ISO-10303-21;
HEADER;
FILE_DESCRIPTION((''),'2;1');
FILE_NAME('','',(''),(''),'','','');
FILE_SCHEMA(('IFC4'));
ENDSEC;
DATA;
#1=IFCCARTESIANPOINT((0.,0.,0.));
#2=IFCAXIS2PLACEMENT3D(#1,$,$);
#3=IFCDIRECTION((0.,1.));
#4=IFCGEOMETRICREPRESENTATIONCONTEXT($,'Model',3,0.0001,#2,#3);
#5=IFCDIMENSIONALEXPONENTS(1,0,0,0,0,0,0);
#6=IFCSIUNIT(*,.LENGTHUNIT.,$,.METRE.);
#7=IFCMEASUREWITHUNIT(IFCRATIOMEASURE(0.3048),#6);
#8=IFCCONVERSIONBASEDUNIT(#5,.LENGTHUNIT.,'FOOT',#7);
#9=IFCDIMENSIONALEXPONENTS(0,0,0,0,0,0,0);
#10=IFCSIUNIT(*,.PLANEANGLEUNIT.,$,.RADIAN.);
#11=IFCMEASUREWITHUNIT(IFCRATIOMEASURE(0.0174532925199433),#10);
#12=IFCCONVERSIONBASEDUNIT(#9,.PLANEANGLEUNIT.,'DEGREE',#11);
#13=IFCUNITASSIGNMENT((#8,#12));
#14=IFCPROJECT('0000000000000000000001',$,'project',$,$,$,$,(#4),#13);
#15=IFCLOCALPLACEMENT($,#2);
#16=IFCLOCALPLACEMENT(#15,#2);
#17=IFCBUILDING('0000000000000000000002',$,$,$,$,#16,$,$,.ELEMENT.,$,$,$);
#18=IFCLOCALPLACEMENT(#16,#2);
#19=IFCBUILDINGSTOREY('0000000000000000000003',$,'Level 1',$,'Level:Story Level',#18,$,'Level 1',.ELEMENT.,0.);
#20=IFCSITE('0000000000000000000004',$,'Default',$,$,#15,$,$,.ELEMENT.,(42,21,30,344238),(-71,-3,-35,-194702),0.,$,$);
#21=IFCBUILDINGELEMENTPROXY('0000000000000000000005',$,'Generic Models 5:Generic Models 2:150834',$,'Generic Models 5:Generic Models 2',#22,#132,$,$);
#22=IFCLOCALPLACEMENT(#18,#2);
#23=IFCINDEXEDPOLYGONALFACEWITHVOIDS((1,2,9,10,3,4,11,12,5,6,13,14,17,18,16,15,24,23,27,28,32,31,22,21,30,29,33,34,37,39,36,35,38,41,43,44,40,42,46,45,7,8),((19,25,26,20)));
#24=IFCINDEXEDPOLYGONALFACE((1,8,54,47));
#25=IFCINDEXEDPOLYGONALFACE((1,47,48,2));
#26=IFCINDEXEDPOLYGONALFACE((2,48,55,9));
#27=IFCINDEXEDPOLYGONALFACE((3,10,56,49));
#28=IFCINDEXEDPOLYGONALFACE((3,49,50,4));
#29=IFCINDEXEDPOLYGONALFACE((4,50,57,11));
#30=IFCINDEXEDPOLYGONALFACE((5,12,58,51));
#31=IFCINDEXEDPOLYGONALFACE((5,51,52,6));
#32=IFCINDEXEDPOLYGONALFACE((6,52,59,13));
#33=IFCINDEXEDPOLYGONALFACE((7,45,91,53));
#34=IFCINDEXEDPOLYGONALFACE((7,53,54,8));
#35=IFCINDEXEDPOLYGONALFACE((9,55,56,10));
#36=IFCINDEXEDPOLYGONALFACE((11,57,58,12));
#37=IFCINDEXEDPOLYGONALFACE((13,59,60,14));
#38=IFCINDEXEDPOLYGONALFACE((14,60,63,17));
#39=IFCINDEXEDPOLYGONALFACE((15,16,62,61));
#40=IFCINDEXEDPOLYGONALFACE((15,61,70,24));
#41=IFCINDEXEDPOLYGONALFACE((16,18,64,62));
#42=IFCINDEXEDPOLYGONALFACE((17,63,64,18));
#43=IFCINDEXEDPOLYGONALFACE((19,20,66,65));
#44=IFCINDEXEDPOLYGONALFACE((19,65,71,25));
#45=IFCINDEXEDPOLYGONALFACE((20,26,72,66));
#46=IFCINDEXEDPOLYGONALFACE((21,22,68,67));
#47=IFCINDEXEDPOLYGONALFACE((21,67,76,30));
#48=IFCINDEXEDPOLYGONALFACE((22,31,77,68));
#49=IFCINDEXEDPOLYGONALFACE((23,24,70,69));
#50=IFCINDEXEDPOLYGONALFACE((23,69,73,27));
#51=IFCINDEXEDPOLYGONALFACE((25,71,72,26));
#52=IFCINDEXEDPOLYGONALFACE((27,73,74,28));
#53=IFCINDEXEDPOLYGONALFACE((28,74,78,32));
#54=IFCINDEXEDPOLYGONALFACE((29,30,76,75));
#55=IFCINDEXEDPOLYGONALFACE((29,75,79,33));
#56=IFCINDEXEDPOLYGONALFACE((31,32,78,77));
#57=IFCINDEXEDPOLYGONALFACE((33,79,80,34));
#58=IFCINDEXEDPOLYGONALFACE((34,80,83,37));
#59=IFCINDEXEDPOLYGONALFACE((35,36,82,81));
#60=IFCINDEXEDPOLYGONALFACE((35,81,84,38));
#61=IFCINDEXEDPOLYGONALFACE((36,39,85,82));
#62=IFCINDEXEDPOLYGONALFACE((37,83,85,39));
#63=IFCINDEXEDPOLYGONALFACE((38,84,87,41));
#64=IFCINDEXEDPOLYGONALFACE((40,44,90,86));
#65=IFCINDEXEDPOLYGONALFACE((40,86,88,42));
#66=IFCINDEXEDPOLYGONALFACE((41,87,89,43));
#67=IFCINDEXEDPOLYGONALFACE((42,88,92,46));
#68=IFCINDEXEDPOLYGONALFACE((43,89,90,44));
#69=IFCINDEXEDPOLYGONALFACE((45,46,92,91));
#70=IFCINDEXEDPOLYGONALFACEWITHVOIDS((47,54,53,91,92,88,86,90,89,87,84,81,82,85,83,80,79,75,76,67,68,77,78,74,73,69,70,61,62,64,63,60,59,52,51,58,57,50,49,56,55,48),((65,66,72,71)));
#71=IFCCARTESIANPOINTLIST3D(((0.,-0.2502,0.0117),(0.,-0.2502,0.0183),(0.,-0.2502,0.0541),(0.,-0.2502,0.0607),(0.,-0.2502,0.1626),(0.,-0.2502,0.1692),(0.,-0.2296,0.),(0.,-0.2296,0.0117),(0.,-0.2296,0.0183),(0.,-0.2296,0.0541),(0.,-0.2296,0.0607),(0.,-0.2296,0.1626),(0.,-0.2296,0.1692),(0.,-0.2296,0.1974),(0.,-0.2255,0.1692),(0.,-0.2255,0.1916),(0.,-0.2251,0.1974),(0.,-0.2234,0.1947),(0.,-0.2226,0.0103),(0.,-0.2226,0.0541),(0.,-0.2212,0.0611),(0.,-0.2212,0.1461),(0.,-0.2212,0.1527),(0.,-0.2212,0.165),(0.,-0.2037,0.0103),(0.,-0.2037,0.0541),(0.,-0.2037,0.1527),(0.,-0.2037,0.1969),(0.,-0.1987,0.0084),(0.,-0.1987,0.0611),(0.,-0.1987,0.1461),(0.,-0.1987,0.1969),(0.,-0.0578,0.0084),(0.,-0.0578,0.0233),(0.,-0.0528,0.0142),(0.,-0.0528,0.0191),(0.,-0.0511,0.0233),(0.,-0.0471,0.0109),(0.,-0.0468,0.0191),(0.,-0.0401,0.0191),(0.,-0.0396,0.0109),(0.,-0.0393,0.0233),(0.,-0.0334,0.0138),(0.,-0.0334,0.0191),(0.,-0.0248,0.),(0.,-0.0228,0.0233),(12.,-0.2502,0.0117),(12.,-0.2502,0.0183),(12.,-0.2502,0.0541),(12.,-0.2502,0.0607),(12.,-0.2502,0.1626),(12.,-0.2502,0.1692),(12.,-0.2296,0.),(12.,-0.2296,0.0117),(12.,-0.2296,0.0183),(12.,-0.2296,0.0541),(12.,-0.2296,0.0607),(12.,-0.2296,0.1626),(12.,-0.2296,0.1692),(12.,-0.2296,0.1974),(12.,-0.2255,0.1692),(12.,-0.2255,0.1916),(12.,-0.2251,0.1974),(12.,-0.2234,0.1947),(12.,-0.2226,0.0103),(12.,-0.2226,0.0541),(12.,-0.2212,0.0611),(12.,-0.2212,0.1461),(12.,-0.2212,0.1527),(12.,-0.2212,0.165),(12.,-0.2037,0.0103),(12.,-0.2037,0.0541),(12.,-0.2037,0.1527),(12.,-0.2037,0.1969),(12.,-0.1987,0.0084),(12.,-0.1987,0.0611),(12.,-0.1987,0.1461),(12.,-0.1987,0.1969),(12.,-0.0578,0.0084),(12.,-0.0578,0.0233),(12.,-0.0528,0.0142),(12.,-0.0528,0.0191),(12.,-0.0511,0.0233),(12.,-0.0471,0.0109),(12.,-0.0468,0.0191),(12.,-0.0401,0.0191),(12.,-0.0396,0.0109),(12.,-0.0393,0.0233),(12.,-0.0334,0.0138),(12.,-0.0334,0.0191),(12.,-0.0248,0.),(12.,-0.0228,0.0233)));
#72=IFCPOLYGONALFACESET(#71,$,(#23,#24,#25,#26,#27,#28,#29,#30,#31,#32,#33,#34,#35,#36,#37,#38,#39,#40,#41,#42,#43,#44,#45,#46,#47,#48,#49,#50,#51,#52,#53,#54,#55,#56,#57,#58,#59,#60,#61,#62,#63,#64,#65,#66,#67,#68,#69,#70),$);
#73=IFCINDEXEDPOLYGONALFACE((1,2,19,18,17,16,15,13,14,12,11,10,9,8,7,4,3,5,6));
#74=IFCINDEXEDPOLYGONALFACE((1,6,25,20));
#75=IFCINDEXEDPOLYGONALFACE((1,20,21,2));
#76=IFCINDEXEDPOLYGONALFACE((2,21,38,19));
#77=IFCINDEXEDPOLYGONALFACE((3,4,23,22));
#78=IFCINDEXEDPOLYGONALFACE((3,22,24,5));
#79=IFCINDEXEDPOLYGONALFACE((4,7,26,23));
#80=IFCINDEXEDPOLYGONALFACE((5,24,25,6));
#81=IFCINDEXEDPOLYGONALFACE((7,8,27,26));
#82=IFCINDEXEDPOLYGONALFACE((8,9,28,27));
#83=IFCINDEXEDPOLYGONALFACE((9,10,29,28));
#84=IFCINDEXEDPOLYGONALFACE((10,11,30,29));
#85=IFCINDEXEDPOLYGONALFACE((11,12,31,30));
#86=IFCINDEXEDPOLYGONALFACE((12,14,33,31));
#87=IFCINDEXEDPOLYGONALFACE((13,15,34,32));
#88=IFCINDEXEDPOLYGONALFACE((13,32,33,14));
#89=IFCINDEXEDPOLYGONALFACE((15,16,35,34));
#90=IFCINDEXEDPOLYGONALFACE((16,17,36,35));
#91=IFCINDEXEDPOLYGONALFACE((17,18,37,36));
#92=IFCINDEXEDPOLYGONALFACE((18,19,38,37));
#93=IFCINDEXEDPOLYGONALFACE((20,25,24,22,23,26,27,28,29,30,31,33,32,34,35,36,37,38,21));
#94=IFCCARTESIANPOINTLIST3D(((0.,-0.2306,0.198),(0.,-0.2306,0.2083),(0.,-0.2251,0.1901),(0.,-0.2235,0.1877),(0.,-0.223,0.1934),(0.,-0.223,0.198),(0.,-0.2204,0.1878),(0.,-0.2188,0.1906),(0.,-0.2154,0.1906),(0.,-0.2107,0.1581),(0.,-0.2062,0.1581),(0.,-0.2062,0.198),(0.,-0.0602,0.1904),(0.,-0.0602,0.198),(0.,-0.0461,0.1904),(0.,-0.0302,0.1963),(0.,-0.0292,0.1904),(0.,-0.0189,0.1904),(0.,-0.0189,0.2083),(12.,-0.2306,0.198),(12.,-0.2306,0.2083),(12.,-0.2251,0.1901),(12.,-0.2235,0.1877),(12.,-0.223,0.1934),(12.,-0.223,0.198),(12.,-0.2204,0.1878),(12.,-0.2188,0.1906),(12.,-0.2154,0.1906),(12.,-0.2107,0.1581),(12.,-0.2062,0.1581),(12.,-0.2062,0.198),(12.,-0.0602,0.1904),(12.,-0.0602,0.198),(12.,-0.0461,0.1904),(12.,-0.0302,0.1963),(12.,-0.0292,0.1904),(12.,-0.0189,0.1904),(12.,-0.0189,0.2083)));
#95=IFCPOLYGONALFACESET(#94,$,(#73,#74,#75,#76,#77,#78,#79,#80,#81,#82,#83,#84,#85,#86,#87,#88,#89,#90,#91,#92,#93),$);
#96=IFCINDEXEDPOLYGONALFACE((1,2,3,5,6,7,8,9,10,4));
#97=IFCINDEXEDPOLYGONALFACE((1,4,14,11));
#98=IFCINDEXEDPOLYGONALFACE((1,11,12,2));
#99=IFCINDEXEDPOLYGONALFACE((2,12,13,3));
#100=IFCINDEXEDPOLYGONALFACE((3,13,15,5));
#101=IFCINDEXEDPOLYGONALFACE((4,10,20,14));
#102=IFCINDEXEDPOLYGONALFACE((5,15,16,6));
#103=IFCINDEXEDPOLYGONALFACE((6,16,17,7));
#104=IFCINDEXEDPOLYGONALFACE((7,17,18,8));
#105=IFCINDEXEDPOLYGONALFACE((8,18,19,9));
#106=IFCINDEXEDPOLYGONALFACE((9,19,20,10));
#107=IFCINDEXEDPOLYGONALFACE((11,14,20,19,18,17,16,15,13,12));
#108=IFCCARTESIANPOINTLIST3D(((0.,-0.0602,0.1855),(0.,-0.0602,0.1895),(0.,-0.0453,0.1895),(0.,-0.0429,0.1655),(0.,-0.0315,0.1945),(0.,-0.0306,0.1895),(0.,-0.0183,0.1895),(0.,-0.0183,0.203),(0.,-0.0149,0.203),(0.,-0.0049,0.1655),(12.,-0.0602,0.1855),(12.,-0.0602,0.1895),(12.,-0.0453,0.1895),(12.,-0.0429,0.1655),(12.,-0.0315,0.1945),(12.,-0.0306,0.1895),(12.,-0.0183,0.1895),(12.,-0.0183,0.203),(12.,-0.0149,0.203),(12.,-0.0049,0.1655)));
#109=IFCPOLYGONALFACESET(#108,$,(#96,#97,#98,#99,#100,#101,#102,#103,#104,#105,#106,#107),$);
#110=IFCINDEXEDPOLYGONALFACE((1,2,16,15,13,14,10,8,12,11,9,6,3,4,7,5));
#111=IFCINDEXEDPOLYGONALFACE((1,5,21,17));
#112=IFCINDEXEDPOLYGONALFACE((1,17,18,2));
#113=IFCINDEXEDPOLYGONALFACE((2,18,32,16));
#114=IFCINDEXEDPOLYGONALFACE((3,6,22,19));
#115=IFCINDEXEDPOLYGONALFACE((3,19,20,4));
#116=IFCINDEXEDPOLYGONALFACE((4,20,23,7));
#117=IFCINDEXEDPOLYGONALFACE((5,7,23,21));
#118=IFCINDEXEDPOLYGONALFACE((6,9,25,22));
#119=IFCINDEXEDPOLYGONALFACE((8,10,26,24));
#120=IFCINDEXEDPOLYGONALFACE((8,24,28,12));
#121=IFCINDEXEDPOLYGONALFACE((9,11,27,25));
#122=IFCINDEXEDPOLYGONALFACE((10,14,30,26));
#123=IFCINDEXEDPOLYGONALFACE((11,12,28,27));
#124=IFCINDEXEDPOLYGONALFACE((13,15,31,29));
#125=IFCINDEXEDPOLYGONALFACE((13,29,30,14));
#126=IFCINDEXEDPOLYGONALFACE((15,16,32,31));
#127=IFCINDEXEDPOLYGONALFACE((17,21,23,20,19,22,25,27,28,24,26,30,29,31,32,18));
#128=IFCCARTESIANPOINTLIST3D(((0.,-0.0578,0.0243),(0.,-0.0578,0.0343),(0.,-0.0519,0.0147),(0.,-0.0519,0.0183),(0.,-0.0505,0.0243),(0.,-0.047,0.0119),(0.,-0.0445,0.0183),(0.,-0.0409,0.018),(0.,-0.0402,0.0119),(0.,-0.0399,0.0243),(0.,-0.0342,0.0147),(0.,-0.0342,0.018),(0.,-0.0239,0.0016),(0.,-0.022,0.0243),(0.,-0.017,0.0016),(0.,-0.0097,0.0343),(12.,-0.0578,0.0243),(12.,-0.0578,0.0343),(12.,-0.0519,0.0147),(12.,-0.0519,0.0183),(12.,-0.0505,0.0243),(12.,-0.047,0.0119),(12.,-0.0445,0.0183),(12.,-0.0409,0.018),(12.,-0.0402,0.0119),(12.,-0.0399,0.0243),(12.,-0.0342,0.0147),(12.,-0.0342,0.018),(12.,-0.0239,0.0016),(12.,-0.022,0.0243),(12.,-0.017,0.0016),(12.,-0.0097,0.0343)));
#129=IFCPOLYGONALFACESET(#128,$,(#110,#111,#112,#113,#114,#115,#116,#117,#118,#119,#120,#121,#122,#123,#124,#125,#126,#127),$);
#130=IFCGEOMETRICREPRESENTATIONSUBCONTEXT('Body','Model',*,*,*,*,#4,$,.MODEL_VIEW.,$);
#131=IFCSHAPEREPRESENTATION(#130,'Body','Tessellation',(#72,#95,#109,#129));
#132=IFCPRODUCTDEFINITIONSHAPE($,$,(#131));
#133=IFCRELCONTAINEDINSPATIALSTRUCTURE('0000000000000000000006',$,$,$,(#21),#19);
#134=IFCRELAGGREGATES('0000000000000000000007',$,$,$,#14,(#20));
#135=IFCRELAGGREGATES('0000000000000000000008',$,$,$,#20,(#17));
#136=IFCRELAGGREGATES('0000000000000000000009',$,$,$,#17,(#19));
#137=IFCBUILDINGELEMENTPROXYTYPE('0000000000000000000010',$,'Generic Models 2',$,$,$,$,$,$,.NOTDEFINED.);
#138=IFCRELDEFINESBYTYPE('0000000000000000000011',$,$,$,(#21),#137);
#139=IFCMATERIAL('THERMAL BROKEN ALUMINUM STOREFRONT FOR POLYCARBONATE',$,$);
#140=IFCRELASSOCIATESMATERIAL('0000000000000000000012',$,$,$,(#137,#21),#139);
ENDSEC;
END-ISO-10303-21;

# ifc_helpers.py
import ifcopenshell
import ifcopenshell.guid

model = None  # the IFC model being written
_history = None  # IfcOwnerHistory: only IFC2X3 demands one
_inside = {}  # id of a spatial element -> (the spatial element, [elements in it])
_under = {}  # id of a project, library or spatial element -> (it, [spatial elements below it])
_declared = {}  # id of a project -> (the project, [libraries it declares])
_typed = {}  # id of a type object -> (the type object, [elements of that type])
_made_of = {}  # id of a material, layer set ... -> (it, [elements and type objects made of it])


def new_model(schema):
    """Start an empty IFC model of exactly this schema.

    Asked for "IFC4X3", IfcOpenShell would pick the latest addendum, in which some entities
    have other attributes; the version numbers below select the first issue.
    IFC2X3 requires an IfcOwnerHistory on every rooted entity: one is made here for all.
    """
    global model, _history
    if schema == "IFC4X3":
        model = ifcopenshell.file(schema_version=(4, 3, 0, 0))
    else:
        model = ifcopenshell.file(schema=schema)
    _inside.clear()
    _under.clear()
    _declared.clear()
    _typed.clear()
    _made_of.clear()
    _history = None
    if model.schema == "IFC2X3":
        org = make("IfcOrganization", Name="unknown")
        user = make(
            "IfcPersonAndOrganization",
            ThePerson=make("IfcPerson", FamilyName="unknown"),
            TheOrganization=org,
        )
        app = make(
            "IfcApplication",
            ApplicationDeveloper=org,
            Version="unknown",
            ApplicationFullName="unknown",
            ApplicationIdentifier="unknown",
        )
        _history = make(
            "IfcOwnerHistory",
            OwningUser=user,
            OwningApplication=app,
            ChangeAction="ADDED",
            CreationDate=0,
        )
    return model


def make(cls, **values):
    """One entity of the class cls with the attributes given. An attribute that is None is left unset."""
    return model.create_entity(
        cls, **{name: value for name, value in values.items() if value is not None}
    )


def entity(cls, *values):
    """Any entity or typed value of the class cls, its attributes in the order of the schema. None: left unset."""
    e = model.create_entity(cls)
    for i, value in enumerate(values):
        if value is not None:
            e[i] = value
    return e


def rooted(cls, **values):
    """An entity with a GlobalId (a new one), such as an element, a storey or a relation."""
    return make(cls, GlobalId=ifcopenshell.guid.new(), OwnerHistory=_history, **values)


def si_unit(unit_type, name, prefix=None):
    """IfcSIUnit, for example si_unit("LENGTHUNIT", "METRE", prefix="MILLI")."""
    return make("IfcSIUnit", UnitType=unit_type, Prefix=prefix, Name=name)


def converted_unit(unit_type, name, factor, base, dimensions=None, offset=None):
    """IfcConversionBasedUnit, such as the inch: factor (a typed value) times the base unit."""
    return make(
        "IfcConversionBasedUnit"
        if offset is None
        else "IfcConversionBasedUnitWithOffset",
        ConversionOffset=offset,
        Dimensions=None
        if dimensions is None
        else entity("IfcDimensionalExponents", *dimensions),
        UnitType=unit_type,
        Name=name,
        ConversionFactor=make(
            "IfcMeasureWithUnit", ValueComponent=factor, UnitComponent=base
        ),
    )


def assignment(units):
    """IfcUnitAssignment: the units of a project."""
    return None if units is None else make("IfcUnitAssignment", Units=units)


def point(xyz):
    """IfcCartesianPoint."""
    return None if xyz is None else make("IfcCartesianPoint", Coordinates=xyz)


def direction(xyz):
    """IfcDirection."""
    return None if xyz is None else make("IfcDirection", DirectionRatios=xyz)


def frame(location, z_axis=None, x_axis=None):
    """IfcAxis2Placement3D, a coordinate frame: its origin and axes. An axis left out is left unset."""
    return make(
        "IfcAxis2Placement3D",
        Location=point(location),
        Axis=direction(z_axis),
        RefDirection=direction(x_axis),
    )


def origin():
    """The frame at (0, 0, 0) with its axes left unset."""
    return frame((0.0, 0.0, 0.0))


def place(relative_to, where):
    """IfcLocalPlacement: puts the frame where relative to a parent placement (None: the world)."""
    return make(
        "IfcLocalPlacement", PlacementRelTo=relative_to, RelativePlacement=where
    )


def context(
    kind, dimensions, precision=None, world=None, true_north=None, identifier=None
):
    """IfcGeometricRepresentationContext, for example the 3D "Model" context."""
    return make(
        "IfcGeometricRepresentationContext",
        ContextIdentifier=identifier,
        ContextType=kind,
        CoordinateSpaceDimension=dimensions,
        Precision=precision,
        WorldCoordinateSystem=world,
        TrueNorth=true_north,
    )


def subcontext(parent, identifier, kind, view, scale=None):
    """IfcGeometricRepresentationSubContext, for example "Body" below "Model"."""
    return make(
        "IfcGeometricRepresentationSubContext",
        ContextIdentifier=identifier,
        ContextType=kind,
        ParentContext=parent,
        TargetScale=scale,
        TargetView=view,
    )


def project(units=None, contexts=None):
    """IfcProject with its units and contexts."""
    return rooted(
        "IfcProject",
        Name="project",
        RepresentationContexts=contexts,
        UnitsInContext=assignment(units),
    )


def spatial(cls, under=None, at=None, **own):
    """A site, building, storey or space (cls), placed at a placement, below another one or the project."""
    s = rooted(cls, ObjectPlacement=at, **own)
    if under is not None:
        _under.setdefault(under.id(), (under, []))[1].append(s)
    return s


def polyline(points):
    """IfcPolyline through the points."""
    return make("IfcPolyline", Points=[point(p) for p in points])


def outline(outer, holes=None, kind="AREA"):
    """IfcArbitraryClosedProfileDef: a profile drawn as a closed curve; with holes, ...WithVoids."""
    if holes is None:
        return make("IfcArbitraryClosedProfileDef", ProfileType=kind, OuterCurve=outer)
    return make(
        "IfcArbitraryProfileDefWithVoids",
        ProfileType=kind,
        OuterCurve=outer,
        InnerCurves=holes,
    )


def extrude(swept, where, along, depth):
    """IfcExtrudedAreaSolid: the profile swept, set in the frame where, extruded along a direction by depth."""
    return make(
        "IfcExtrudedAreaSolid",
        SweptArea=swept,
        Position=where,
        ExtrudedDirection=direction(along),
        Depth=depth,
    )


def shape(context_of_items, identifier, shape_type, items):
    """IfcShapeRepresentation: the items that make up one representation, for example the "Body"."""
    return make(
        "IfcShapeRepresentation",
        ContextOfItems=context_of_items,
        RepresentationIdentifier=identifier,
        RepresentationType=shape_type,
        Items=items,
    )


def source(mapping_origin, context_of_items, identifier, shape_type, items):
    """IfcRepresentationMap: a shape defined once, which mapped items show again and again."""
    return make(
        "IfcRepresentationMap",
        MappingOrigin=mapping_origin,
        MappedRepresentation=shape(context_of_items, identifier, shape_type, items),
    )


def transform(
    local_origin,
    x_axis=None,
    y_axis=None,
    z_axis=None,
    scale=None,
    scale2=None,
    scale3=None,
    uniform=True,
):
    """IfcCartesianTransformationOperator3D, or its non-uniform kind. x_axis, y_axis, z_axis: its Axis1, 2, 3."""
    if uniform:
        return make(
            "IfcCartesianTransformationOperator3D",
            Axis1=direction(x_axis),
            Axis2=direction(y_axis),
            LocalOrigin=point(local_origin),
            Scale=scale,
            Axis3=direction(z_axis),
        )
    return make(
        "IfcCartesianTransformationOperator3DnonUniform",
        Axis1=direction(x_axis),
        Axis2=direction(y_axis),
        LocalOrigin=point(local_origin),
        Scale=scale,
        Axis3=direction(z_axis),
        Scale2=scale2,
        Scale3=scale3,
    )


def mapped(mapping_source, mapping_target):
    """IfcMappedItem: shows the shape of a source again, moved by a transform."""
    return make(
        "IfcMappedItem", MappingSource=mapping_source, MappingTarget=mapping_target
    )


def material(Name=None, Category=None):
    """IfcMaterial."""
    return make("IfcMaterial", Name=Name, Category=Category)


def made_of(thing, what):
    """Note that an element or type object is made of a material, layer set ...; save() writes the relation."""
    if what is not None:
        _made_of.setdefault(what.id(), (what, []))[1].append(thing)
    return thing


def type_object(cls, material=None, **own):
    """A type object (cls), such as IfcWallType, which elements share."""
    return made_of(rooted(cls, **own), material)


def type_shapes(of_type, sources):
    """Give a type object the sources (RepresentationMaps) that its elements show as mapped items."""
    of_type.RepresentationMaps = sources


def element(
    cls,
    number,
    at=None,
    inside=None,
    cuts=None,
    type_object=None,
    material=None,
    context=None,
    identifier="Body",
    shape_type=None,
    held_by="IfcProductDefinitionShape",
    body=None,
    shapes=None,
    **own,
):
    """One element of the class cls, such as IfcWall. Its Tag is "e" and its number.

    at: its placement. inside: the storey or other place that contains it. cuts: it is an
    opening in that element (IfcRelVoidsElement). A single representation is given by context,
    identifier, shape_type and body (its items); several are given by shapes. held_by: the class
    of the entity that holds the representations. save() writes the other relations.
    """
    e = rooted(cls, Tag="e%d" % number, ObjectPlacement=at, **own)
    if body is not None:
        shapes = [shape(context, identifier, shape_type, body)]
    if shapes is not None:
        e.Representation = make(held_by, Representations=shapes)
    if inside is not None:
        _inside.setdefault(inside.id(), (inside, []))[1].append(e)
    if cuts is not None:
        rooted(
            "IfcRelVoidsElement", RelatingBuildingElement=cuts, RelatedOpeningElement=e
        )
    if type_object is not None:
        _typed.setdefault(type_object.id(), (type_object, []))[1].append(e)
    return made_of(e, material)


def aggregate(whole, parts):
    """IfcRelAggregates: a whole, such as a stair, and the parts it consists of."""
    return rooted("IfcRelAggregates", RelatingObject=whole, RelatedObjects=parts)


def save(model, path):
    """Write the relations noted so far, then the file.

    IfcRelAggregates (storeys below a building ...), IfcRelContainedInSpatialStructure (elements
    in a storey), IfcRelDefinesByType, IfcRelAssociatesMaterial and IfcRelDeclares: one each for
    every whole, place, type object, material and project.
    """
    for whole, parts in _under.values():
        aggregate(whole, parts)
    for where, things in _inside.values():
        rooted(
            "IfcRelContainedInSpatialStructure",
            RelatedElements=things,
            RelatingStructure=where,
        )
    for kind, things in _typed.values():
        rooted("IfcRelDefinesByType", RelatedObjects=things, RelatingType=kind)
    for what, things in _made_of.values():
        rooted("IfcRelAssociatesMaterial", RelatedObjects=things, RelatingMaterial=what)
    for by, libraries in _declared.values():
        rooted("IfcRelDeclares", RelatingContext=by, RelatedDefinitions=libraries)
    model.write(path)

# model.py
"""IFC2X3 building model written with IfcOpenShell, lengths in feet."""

from ifc_helpers import new_model, entity, si_unit, converted_unit, direction, frame, origin, place, context, subcontext, project, spatial, polyline, outline, extrude, source, transform, mapped, material, type_object, type_shapes, element, save


model = new_model("IFC2X3")

# Units and contexts
model_context = context("Model", 3, precision=0.0001, world=origin(), true_north=direction((0.0, 1.0)))
body_context = subcontext(model_context, "Body", "Model", "MODEL_VIEW")
ifc_project = project(units=[converted_unit("LENGTHUNIT", "FOOT", entity("IfcRatioMeasure", 0.3048), si_unit("LENGTHUNIT", "METRE"), dimensions=[1, 0, 0, 0, 0, 0, 0]), converted_unit("PLANEANGLEUNIT", "DEGREE", entity("IfcRatioMeasure", 0.0174532925199433), si_unit("PLANEANGLEUNIT", "RADIAN"), dimensions=[0, 0, 0, 0, 0, 0, 0])], contexts=[model_context])

# Site, building, storey
site_placement = place(None, origin())
site = spatial("IfcSite", under=ifc_project, at=site_placement, Name="Default", CompositionType="ELEMENT", RefLatitude=(42, 21, 30, 344238), RefLongitude=(-71, -3, -35, -194702), RefElevation=0.0)
building_placement = place(site_placement, origin())
building = spatial("IfcBuilding", under=site, at=building_placement, CompositionType="ELEMENT")
storey_placement = place(building_placement, origin())
storey = spatial("IfcBuildingStorey", under=building, at=storey_placement, Name="Level 1", ObjectType="Level:Story Level", LongName="Level 1", CompositionType="ELEMENT", Elevation=0.0)

# Building element proxy
ifc_material = material(Name="THERMAL BROKEN ALUMINUM STOREFRONT FOR POLYCARBONATE")
building_element_proxy_type_1 = type_object("IfcBuildingElementProxyType", Name="Generic Models 2", PredefinedType="NOTDEFINED", material=ifc_material)
shared_shape_1 = source(origin(), body_context, "Body", "SweptSolid", [
    extrude(outline(polyline([(-0.107, -0.073), (-0.107, -0.058), (-0.1137, -0.058), (-0.118, -0.0623), (-0.1121, -0.0623), (-0.1121, -0.0672), (-0.1177, -0.0704), (-0.1252, -0.0704), (-0.1315, -0.0675), (-0.1315, -0.0623), (-0.1248, -0.0623), (-0.1255, -0.058), (-0.142, -0.058), (-0.1401, -0.0814), (0.0647, -0.0814), (0.0647, -0.0697), (0.0853, -0.0697), (0.0853, -0.0631), (0.0647, -0.0631), (0.0647, -0.0273), (0.0853, -0.0273), (0.0853, -0.0207), (0.0647, -0.0207), (0.0647, 0.0812), (0.0853, 0.0812), (0.0853, 0.0878), (0.0647, 0.0878), (0.0647, 0.1161), (0.0603, 0.1161), (0.0585, 0.1133), (0.0606, 0.1102), (0.0606, 0.0878), (0.0564, 0.0836), (0.0564, 0.0713), (0.0389, 0.0713), (0.0389, 0.1155), (0.0338, 0.1155), (0.0338, 0.0647), (0.0564, 0.0647), (0.0564, -0.0203), (0.0338, -0.0203), (0.0338, -0.073), (-0.107, -0.073)]), holes=[polyline([(0.0577, -0.0711), (0.0389, -0.0711), (0.0389, -0.0273), (0.0577, -0.0273), (0.0577, -0.0711)])]), frame((0.0, -0.118, -0.2198), z_axis=(-1.0, 0.0, 0.0), x_axis=(0.0, -1.0, 0.0)), (0.0, 0.0, -1.0), 12.0),
    extrude(outline(polyline([(-0.0355, -0.058), (-0.0371, -0.0606), (-0.0358, -0.0632), (-0.0318, -0.063), (-0.0278, -0.0652), (-0.0315, -0.0718), (-0.0224, -0.0768), (0.0802, 0.1083), (0.0645, 0.1169), (0.0595, 0.1079), (0.0642, 0.1042), (0.0513, 0.0931), (0.0445, 0.0809), (0.0512, 0.0772), (-0.0197, -0.0506), (-0.0545, -0.0312), (-0.0567, -0.0352), (-0.0306, -0.055), (-0.0322, -0.058), (-0.0355, -0.058)])), frame((0.0, -0.1056, -0.1105), z_axis=(-1.0, 0.0, 0.0), x_axis=(0.0, 0.484974, 0.874529)), (0.0, 0.0, -1.0), 12.0),
    extrude(outline(polyline([(-0.0178, -0.0155), (-0.0144, -0.0155), (-0.0144, -0.002), (-0.0021, -0.002), (-0.0012, -0.007), (0.0126, -0.002), (0.0275, -0.002), (0.0275, 0.002), (0.0102, 0.022), (-0.0278, 0.022), (-0.0178, -0.0155)])), frame((0.0, 0.0142, -0.1136), z_axis=(1.0, 0.0, 0.0), x_axis=(0.0, -1.0, 0.0)), (0.0, 0.0, 1.0), 12.0),
    extrude(outline(polyline([(-0.0292, -0.0159), (0.0189, -0.0159), (0.0189, -0.0059), (0.0115, -0.0059), (0.0055, 0.0001), (0.0129, 0.0001), (0.0129, 0.0037), (0.008, 0.0065), (0.0012, 0.0065), (-0.0047, 0.0038), (-0.0047, 0.0004), (0.002, 0.0004), (0.0009, -0.0059), (-0.017, -0.0059), (-0.015, 0.0168), (-0.0219, 0.0168), (-0.0292, -0.0159)])), frame((0.0, 0.0079, -0.2827), z_axis=(1.0, 0.0, 0.0), x_axis=(0.0, -1.0, 0.0)), (0.0, 0.0, 1.0), 12.0),
])
type_shapes(building_element_proxy_type_1, [shared_shape_1])
proxy_1_placement = place(storey_placement, frame((0.0, -0.0469, 0.3012)))
element("IfcBuildingElementProxy", 1, at=proxy_1_placement, inside=storey, type_object=building_element_proxy_type_1, material=ifc_material, Name="Generic Models 5:Generic Models 2:150834", ObjectType="Generic Models 5:Generic Models 2", context=body_context, shape_type="MappedRepresentation", body=[
    mapped(shared_shape_1, transform((0.0, 0.0, 0.0), scale=1.0)),
])

save(model, "model.ifc")
